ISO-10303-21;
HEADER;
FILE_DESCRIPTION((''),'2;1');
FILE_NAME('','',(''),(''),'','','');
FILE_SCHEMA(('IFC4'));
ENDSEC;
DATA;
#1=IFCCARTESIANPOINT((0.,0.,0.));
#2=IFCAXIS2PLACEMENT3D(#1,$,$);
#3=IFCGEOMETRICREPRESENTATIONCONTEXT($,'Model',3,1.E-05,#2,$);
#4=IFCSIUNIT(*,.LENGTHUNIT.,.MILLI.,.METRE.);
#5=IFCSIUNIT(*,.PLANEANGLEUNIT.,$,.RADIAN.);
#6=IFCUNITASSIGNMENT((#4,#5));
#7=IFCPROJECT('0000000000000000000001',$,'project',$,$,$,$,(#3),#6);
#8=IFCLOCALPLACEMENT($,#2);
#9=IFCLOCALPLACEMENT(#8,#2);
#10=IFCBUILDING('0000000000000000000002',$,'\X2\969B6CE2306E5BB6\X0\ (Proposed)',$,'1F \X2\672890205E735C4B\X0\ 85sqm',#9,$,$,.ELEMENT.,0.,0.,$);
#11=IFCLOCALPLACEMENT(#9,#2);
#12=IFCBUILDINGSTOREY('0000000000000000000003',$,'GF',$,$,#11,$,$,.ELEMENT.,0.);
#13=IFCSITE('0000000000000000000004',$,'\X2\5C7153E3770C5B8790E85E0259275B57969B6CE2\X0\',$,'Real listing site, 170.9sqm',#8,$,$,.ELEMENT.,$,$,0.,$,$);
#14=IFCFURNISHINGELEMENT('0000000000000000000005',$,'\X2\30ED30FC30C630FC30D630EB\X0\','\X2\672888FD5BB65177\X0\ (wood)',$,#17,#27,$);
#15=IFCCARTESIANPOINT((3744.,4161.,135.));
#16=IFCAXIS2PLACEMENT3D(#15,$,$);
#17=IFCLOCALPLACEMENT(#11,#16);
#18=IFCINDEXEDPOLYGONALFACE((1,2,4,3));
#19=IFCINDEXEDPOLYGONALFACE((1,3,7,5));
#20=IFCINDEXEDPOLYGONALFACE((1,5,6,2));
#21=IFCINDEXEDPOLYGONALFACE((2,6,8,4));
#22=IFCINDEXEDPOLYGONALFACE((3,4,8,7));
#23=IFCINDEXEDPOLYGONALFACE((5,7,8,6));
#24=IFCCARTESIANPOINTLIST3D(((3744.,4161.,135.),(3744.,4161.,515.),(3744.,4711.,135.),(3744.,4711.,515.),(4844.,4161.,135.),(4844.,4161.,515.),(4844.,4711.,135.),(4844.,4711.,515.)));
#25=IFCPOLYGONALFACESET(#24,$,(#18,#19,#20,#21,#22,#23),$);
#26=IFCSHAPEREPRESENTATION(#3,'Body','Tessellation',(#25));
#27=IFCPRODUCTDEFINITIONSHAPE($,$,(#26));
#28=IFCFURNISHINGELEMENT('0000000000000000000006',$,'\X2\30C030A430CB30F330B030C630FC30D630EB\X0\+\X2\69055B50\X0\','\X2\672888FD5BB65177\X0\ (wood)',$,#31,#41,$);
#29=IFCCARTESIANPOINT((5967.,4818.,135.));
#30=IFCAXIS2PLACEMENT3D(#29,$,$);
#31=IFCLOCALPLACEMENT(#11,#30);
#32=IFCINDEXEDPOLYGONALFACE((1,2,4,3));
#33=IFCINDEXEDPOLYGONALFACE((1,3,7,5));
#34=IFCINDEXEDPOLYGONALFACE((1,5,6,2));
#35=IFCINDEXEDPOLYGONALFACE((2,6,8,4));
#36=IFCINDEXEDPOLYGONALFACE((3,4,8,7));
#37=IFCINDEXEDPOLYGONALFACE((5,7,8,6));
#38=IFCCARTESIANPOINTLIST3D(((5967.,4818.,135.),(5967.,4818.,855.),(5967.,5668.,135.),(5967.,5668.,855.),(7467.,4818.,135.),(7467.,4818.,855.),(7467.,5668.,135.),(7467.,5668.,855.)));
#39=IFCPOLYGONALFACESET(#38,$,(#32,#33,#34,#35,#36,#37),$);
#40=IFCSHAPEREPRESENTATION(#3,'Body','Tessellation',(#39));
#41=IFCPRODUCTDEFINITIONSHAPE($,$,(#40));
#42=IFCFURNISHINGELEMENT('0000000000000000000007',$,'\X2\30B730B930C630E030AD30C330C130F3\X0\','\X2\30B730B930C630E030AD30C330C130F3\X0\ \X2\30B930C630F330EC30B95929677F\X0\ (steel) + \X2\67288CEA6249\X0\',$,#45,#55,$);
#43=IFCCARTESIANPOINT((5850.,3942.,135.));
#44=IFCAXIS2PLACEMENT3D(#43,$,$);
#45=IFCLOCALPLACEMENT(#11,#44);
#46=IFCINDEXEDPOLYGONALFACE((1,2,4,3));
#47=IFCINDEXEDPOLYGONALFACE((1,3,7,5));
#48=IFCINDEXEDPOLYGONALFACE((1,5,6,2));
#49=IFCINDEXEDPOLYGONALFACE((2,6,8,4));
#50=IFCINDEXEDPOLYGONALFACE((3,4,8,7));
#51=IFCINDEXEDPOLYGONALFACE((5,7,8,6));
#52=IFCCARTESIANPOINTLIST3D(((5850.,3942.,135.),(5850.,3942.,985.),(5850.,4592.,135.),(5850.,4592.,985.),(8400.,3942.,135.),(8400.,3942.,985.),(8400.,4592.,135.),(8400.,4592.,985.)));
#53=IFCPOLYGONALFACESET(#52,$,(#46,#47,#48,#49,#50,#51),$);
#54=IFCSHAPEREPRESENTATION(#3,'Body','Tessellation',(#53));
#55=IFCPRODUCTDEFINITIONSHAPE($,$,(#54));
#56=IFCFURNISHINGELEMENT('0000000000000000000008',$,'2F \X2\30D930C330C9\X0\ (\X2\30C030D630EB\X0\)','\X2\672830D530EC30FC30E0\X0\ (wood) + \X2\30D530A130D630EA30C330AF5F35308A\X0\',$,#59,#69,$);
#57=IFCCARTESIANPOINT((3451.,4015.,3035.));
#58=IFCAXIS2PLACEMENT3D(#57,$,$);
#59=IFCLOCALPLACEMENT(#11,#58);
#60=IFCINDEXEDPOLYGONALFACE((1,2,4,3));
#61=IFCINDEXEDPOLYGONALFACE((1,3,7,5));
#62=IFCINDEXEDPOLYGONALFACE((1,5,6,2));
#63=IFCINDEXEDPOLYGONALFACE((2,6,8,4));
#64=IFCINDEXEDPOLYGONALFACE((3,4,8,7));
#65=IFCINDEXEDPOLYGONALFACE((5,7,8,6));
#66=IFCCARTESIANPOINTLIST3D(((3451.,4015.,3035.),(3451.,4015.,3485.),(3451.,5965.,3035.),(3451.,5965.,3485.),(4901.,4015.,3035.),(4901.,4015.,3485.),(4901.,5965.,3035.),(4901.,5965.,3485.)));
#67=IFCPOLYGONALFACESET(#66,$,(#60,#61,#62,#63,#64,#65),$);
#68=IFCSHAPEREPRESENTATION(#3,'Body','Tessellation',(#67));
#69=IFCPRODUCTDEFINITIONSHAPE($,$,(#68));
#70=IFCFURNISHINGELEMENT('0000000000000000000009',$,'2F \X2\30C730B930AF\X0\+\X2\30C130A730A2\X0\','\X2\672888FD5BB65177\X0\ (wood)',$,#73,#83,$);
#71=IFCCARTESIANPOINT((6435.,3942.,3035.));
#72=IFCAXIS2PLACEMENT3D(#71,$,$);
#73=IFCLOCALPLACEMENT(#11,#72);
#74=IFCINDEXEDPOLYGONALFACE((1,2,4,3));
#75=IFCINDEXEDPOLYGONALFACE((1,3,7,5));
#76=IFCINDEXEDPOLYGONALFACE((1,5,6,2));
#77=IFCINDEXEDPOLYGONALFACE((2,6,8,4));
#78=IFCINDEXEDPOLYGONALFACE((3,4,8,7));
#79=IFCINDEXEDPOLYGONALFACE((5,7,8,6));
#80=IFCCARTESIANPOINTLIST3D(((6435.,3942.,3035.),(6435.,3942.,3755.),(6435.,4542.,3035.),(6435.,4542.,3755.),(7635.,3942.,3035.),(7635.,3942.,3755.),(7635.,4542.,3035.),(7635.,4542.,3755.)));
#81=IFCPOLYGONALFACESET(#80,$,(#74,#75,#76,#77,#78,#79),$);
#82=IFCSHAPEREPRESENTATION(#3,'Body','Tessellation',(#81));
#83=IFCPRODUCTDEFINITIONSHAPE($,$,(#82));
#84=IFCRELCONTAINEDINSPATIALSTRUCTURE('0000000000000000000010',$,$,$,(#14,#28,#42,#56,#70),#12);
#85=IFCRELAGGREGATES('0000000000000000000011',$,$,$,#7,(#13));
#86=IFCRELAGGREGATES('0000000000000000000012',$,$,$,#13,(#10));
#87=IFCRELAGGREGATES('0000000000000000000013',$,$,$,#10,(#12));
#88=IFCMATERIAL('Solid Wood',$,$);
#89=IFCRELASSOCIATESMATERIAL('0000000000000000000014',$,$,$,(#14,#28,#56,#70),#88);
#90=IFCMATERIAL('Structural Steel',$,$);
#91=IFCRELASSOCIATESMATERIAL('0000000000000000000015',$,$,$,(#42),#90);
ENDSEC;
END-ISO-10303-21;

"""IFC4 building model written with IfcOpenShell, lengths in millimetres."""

from ifc_helpers import new_model, si_unit, frame, frame_2d, origin, place, context, project, spatial, rectangle, extrude, material, element, save


model = new_model("IFC4")

# Units and contexts
model_context = context("Model", 3, precision=1e-05, world=origin())
ifc_project = project(units=[si_unit("LENGTHUNIT", "METRE", prefix="MILLI"), si_unit("PLANEANGLEUNIT", "RADIAN")], contexts=[model_context])

# Site, building, storey
site_placement = place(None, origin())
site = spatial("IfcSite", under=ifc_project, at=site_placement, Name="山口県宇部市大字際波", ObjectType="Real listing site, 170.9sqm", CompositionType="ELEMENT", RefElevation=0.0)
building_placement = place(site_placement, origin())
building = spatial("IfcBuilding", under=site, at=building_placement, Name="際波の家 (Proposed)", ObjectType="1F 木造平屋 85sqm", CompositionType="ELEMENT", ElevationOfRefHeight=0.0, ElevationOfTerrain=0.0)
storey_placement = place(building_placement, origin())
storey = spatial("IfcBuildingStorey", under=building, at=storey_placement, Name="GF", CompositionType="ELEMENT", Elevation=0.0)

# Shared definitions
ifc_material_1 = material(Name="Solid Wood")

# Shared definitions
ifc_material_2 = material(Name="Structural Steel")

# Furnishing elements
furnishing_1_placement = place(storey_placement, frame((3744.0, 4161.0, 135.0)))
element("IfcFurnishingElement", 1, at=furnishing_1_placement, inside=storey, material=ifc_material_1, Name="ローテーブル", Description="木製家具 (wood)", context=model_context, shape_type="SweptSolid", body=[
    extrude(rectangle(XDim=1100.0, YDim=550.0, at=frame_2d((550.0, 275.0))), frame((3744.0, 4161.0, 135.0)), (0.0, 0.0, 1.0), 380.0),
])
furnishing_2_placement = place(storey_placement, frame((5967.0, 4818.0, 135.0)))
element("IfcFurnishingElement", 2, at=furnishing_2_placement, inside=storey, material=ifc_material_1, Name="ダイニングテーブル+椅子", Description="木製家具 (wood)", context=model_context, shape_type="SweptSolid", body=[
    extrude(rectangle(XDim=1500.0, YDim=850.0, at=frame_2d((750.0, 425.0))), frame((5967.0, 4818.0, 135.0)), (0.0, 0.0, 1.0), 720.0),
])
furnishing_3_placement = place(storey_placement, frame((5850.0, 3942.0, 135.0)))
element("IfcFurnishingElement", 3, at=furnishing_3_placement, inside=storey, material=ifc_material_2, Name="システムキッチン", Description="システムキッチン ステンレス天板 (steel) + 木質扉", context=model_context, shape_type="SweptSolid", body=[
    extrude(rectangle(XDim=2550.0, YDim=650.0, at=frame_2d((1275.0, 325.0))), frame((5850.0, 3942.0, 135.0)), (0.0, 0.0, 1.0), 850.0),
])
furnishing_4_placement = place(storey_placement, frame((3451.0, 4015.0, 3035.0)))
element("IfcFurnishingElement", 4, at=furnishing_4_placement, inside=storey, material=ifc_material_1, Name="2F ベッド (ダブル)", Description="木フレーム (wood) + ファブリック張り", context=model_context, shape_type="SweptSolid", body=[
    extrude(rectangle(XDim=1450.0, YDim=1950.0, at=frame_2d((725.0, 975.0))), frame((3451.0, 4015.0, 3035.0)), (0.0, 0.0, 1.0), 450.0),
])
furnishing_5_placement = place(storey_placement, frame((6435.0, 3942.0, 3035.0)))
element("IfcFurnishingElement", 5, at=furnishing_5_placement, inside=storey, material=ifc_material_1, Name="2F デスク+チェア", Description="木製家具 (wood)", context=model_context, shape_type="SweptSolid", body=[
    extrude(rectangle(XDim=1200.0, YDim=600.0, at=frame_2d((600.0, 300.0))), frame((6435.0, 3942.0, 3035.0)), (0.0, 0.0, 1.0), 720.0),
])

save(model, "model.ifc")
